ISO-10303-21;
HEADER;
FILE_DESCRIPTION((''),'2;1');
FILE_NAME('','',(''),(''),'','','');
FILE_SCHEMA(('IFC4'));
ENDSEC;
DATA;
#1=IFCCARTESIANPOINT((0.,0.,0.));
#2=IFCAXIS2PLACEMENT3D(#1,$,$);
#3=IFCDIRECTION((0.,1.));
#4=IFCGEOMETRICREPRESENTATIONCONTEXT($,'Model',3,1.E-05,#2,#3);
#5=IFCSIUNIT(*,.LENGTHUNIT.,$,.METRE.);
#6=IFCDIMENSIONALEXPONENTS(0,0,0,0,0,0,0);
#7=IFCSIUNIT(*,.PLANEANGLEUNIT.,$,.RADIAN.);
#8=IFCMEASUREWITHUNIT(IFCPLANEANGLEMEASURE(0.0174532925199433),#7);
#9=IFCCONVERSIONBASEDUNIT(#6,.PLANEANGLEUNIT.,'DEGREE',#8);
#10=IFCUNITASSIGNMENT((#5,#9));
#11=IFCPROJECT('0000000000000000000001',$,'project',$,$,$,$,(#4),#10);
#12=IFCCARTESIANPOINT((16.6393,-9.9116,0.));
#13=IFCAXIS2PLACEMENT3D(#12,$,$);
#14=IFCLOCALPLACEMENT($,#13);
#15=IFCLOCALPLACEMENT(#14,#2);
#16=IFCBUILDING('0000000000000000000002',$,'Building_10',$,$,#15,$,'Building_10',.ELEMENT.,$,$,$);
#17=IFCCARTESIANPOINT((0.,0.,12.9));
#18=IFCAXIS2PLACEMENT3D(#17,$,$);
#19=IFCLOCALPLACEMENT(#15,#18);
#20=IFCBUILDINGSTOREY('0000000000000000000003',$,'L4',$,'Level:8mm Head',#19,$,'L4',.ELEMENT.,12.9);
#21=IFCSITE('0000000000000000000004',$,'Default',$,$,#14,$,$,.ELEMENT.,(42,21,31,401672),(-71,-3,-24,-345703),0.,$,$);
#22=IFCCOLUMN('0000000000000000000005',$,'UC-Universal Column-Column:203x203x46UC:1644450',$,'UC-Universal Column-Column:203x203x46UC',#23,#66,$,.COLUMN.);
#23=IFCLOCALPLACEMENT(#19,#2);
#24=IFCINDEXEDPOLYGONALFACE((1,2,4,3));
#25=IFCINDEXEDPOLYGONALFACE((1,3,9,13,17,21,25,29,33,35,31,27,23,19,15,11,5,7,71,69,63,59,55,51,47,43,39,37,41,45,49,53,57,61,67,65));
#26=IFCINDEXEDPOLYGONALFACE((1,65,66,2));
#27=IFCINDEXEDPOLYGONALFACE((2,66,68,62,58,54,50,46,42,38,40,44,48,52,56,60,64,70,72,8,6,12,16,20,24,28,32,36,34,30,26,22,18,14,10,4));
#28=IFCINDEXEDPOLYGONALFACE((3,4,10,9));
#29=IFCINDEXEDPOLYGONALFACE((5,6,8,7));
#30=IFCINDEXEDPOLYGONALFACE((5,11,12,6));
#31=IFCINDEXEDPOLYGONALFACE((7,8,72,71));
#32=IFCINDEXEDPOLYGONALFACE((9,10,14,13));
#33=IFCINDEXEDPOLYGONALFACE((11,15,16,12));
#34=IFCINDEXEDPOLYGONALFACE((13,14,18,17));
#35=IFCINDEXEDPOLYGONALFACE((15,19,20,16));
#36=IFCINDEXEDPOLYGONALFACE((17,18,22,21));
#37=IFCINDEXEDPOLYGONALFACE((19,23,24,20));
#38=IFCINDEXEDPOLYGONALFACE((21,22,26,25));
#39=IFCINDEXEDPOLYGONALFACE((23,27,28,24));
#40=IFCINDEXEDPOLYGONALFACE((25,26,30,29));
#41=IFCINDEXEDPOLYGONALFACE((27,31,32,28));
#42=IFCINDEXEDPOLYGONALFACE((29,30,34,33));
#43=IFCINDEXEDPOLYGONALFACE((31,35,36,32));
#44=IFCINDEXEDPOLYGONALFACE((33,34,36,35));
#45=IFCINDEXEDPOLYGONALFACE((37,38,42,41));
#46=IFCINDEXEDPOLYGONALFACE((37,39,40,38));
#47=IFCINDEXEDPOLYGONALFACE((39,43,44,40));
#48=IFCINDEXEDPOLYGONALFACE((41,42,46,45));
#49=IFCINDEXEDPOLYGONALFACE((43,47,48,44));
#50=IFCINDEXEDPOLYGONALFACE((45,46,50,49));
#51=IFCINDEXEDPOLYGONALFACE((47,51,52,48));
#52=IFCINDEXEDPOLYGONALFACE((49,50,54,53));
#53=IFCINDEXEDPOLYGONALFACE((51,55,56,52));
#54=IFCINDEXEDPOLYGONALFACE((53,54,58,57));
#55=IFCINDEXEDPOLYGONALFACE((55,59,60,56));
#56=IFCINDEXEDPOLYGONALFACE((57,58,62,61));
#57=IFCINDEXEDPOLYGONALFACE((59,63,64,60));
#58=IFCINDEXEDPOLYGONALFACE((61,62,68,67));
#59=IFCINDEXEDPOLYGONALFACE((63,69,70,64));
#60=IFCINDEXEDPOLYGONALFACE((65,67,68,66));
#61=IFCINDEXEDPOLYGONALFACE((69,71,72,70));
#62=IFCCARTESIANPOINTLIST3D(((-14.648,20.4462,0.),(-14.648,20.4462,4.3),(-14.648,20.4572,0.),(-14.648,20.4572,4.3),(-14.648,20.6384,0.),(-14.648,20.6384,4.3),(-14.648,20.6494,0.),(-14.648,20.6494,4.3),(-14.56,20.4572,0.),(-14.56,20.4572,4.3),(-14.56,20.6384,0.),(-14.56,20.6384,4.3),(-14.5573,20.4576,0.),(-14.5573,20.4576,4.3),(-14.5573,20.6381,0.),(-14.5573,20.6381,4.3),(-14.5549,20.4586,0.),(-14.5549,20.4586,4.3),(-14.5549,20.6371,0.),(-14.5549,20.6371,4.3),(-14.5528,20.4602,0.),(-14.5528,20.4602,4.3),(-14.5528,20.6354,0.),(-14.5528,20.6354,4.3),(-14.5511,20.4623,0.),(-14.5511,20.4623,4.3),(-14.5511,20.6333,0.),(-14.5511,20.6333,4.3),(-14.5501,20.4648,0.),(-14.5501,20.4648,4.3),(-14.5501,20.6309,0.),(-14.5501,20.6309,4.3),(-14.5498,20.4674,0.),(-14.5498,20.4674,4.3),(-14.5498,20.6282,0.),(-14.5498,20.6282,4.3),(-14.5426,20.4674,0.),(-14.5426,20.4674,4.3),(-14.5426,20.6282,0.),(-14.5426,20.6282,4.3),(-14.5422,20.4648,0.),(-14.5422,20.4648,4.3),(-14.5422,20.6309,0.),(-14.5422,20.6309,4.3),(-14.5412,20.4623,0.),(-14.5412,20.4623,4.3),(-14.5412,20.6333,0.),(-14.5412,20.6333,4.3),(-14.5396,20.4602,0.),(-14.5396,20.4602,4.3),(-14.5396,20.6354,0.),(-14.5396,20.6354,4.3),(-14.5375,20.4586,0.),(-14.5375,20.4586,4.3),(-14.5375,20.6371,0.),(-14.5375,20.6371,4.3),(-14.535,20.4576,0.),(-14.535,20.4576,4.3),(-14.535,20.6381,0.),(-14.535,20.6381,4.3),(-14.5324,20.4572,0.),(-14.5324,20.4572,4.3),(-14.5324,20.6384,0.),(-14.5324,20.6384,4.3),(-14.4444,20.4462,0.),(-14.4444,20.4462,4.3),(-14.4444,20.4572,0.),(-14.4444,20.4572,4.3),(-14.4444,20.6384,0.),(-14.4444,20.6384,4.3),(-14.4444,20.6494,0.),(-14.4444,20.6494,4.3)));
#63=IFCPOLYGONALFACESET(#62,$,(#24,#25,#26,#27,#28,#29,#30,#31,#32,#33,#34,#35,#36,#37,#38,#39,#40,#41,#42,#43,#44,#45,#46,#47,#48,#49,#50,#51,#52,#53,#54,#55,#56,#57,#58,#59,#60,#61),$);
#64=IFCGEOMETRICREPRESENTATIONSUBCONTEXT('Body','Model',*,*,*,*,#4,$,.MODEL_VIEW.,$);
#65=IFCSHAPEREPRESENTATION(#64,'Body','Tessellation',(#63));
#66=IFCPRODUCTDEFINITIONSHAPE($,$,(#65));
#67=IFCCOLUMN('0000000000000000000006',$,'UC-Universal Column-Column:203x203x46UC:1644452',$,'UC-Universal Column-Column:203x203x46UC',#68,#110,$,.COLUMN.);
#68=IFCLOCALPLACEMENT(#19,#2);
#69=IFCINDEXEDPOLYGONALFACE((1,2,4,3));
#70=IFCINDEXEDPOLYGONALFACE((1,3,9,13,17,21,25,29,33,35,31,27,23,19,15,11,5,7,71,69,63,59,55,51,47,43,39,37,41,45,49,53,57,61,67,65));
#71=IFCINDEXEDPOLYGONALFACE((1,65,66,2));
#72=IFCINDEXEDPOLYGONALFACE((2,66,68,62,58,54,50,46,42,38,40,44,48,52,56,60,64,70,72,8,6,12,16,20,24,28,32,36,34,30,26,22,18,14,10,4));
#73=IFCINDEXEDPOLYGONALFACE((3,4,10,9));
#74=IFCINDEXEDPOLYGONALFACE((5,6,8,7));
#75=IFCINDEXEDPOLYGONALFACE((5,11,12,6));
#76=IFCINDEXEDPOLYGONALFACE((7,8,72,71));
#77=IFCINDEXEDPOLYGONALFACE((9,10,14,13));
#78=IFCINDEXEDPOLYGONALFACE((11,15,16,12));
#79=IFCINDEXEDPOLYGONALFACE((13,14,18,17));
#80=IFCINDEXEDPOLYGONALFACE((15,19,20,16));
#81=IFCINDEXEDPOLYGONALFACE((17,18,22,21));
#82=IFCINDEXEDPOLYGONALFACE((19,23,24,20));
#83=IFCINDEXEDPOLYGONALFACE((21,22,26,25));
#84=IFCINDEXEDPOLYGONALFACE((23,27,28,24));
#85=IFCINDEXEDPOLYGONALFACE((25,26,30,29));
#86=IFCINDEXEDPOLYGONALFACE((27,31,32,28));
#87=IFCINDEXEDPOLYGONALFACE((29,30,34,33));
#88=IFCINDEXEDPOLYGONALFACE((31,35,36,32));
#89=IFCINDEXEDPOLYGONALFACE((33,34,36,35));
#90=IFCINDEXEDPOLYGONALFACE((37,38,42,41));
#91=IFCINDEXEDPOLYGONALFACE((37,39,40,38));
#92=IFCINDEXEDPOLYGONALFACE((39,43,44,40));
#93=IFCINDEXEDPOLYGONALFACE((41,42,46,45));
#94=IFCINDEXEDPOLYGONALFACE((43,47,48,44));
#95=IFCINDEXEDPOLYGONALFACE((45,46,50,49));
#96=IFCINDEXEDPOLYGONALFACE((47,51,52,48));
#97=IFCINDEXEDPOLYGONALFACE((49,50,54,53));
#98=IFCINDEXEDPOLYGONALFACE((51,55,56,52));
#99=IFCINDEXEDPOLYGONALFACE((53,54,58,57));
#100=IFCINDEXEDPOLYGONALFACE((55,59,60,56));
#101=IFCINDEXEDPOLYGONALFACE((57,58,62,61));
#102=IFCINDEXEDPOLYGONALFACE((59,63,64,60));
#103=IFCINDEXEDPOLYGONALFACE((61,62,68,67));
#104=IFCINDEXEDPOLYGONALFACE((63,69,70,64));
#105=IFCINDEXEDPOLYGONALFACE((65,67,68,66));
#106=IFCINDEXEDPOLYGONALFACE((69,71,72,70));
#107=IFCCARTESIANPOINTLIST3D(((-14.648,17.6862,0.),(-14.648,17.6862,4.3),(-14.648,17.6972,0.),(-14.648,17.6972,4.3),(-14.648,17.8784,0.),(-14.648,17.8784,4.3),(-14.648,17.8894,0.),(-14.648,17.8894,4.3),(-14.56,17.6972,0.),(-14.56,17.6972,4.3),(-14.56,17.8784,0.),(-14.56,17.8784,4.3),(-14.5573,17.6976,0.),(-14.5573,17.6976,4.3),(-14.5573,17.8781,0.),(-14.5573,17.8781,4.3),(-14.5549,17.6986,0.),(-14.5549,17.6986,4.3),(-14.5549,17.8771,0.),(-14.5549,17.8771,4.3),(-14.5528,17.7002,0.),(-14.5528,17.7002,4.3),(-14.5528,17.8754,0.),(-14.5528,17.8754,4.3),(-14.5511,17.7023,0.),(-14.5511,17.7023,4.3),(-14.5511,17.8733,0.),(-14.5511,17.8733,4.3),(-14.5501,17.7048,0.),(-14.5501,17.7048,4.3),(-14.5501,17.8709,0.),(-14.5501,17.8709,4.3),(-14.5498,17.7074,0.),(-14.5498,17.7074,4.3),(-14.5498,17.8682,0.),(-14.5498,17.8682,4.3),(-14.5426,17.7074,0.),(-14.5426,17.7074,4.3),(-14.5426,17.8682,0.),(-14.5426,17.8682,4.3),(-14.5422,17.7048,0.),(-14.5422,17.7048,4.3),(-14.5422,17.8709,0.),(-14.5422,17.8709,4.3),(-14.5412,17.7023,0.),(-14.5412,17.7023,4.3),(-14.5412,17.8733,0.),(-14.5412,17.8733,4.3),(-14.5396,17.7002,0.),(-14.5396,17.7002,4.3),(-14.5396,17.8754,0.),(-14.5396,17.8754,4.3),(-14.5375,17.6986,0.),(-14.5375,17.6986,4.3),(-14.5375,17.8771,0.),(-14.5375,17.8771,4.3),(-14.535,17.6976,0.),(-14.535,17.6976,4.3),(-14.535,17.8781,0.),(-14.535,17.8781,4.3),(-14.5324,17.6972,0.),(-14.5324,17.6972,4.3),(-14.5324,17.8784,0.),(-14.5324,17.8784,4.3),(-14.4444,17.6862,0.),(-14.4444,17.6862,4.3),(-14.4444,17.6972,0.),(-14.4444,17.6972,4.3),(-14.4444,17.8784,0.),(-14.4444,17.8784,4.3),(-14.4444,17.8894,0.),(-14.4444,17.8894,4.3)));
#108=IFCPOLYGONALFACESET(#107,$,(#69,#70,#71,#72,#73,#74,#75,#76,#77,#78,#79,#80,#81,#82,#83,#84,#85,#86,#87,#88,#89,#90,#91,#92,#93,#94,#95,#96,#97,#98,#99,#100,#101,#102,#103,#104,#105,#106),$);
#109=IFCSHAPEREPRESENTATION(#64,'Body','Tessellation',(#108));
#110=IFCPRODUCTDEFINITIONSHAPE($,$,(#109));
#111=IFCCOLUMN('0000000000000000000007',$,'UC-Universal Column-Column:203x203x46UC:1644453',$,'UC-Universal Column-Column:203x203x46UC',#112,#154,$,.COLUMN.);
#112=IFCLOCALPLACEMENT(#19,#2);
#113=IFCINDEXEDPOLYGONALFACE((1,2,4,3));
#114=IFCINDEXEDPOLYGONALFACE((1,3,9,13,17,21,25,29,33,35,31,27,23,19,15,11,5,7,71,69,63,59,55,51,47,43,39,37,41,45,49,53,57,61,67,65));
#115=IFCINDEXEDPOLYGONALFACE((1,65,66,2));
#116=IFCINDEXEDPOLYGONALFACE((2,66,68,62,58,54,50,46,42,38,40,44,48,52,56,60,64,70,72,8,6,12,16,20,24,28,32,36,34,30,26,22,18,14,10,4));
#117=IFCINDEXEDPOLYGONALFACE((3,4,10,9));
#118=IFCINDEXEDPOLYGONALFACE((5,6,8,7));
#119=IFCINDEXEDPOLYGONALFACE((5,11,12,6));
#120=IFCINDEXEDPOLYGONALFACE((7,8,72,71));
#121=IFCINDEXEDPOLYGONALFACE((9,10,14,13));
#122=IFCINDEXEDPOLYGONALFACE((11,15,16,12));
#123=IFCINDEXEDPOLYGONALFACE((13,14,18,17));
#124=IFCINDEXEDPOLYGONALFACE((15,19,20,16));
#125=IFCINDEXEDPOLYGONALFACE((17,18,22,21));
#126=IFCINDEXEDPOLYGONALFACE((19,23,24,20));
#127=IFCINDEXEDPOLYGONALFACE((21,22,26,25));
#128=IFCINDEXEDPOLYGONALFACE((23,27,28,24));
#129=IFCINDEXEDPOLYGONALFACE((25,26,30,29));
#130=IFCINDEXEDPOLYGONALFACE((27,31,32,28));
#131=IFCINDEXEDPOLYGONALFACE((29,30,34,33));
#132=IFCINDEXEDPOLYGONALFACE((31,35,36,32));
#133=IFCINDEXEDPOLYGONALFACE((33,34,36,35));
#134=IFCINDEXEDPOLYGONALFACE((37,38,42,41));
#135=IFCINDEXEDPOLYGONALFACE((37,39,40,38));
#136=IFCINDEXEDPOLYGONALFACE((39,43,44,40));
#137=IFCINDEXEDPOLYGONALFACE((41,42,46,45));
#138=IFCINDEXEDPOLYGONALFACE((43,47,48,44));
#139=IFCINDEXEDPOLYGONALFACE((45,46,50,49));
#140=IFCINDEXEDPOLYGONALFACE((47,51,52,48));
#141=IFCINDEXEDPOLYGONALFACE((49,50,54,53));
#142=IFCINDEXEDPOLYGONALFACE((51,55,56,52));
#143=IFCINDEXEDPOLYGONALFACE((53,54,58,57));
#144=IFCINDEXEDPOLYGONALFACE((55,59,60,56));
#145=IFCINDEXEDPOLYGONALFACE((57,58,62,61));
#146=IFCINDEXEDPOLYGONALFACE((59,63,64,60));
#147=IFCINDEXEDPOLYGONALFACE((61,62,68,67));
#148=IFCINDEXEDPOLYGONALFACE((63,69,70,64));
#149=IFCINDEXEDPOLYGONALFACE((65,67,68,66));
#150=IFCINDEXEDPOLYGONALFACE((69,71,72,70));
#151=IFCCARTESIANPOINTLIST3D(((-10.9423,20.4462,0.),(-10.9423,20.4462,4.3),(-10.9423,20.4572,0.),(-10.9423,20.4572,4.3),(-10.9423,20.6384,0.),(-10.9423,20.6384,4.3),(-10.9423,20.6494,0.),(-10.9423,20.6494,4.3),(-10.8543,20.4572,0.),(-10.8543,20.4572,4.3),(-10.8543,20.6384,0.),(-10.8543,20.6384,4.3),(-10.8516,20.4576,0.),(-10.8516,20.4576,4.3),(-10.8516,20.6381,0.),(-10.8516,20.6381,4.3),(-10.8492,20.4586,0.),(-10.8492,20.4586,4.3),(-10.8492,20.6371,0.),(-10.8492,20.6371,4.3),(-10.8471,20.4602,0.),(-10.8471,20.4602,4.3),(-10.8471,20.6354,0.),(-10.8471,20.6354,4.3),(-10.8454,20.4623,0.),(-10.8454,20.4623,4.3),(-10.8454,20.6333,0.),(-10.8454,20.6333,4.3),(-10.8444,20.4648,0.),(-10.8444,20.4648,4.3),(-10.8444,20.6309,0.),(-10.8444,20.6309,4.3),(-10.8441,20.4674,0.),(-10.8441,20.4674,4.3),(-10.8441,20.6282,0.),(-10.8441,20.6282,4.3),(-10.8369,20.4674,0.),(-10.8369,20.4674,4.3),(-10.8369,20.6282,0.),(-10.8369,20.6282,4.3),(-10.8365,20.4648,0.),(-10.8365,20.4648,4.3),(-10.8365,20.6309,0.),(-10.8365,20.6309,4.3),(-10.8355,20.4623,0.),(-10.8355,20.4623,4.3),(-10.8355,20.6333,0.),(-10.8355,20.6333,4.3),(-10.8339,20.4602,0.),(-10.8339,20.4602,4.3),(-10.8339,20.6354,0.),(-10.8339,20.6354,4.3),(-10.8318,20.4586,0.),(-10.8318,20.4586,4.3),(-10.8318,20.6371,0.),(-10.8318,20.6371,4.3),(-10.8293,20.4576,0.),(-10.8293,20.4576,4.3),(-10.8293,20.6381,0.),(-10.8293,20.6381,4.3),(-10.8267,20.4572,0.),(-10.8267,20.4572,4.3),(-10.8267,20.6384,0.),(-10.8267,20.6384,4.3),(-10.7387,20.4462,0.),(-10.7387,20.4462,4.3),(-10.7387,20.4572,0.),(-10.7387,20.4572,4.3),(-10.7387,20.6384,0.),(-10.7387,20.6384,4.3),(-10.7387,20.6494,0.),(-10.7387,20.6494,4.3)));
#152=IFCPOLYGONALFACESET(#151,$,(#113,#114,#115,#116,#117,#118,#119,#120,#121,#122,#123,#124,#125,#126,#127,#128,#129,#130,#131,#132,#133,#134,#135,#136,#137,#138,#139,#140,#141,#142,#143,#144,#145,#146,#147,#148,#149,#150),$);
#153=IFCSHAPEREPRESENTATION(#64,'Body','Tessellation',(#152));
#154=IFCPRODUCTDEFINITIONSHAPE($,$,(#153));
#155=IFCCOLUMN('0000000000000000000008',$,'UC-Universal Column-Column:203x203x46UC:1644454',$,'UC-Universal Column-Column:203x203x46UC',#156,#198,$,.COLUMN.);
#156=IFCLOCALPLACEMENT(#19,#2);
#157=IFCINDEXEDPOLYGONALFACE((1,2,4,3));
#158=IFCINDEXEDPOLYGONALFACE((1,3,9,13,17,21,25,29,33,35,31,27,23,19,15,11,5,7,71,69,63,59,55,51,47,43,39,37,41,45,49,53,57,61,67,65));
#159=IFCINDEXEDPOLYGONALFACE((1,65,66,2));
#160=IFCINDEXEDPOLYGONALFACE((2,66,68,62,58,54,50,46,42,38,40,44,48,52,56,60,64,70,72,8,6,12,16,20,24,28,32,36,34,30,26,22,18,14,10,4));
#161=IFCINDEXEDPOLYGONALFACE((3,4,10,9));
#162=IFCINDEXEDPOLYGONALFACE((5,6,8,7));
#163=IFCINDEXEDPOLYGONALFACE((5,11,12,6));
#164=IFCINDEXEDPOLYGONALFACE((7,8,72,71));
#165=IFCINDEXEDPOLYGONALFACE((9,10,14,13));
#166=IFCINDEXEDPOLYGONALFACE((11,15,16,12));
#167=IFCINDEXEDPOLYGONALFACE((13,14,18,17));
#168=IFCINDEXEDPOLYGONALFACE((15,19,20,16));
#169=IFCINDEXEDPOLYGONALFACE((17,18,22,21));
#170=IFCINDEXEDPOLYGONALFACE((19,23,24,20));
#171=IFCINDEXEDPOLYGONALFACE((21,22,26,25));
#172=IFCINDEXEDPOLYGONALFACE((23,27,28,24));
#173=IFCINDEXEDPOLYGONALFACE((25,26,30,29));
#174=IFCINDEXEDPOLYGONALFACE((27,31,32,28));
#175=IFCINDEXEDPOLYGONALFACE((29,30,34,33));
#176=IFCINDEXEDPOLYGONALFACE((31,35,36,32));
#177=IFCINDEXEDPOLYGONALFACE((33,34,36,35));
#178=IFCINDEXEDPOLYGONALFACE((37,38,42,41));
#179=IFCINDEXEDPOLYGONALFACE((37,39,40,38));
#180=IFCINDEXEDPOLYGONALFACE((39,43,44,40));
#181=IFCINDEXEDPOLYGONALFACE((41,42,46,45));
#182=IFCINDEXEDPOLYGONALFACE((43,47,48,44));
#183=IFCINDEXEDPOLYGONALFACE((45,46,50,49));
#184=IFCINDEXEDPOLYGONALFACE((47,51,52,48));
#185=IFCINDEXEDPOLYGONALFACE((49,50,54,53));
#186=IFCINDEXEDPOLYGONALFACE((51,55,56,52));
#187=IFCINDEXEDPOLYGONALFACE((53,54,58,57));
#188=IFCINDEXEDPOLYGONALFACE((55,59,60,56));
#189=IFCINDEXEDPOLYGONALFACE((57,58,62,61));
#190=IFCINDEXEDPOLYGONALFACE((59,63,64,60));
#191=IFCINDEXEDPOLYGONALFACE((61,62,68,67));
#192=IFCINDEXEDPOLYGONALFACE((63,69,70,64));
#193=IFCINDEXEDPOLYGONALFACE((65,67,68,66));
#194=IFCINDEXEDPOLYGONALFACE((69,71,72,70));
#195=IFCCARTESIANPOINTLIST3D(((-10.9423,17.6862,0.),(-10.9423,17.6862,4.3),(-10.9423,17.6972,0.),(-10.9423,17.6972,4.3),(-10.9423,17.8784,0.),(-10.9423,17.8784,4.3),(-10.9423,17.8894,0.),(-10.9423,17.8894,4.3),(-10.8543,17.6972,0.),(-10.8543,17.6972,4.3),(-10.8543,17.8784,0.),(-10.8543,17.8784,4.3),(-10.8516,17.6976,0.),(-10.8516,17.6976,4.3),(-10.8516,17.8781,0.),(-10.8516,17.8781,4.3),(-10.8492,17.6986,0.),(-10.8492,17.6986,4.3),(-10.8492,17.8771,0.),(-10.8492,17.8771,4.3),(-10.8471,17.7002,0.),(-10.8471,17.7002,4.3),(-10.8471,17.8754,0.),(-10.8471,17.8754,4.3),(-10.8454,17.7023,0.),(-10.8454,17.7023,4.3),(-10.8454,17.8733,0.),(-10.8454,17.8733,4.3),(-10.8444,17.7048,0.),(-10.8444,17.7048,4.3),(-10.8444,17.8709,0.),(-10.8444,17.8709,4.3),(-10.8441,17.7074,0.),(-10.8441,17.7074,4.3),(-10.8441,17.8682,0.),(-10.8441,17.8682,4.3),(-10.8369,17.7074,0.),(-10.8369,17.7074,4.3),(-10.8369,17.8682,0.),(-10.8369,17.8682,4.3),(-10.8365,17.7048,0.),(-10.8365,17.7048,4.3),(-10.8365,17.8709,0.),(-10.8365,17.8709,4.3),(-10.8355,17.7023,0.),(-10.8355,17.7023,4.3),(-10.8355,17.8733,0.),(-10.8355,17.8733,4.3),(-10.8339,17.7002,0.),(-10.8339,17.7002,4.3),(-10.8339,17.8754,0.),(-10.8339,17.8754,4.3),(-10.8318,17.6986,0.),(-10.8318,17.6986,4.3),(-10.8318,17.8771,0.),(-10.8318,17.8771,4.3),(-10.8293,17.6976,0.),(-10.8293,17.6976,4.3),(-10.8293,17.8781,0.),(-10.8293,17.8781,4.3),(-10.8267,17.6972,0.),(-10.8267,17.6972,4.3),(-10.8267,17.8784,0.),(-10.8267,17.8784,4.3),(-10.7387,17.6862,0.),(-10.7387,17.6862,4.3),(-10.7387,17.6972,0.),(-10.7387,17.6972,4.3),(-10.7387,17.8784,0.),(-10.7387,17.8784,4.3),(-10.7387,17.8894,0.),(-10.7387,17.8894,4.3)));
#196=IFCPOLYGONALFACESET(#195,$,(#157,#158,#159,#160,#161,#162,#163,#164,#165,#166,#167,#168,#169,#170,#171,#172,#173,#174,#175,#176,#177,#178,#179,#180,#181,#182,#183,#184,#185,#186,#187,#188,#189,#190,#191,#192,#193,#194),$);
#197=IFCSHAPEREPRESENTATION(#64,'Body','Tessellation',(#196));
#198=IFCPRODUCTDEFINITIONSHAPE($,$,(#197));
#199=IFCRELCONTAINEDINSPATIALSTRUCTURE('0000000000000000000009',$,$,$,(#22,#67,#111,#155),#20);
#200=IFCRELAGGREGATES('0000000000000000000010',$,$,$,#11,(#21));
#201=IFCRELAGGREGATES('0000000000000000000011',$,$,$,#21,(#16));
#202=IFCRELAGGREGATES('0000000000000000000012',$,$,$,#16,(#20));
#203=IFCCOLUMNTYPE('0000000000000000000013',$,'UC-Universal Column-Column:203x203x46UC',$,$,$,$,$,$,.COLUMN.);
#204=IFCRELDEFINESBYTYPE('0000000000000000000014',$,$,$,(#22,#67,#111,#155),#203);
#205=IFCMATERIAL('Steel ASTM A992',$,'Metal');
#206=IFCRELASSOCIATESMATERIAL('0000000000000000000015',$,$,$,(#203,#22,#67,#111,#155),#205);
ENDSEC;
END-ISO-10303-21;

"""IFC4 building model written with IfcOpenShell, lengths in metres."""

from ifc_helpers import new_model, entity, si_unit, converted_unit, direction, frame, origin, place, context, subcontext, project, spatial, line, arc, indexed_curve, outline, extrude, source, transform, mapped, material, type_object, type_shapes, element, save


model = new_model("IFC4")

# Units and contexts
model_context = context("Model", 3, precision=1e-05, world=origin(), true_north=direction((0.0, 1.0)))
body_context = subcontext(model_context, "Body", "Model", "MODEL_VIEW")
ifc_project = project(units=[si_unit("LENGTHUNIT", "METRE"), converted_unit("PLANEANGLEUNIT", "DEGREE", entity("IfcPlaneAngleMeasure", 0.0174532925199433), si_unit("PLANEANGLEUNIT", "RADIAN"), dimensions=[0, 0, 0, 0, 0, 0, 0])], contexts=[model_context])

# Site, building, storey
site_placement = place(None, frame((16.6393, -9.9116, 0.0)))
site = spatial("IfcSite", under=ifc_project, at=site_placement, Name="Default", CompositionType="ELEMENT", RefLatitude=(42, 21, 31, 401672), RefLongitude=(-71, -3, -24, -345703), RefElevation=0.0)
building_placement = place(site_placement, origin())
building = spatial("IfcBuilding", under=site, at=building_placement, Name="Building_10", LongName="Building_10", CompositionType="ELEMENT")
storey_placement = place(building_placement, frame((0.0, 0.0, 12.9)))
storey = spatial("IfcBuildingStorey", under=building, at=storey_placement, Name="L4", ObjectType="Level:8mm Head", LongName="L4", CompositionType="ELEMENT", Elevation=12.9)

# Columns
ifc_material_1 = material(Name="Steel ASTM A992", Category="Metal")
column_type = type_object("IfcColumnType", Name="UC-Universal Column-Column:203x203x46UC", PredefinedType="COLUMN", material=ifc_material_1)
shared_shape_1 = source(origin(), body_context, "Body", "SweptSolid", [
    extrude(outline(indexed_curve([(-0.1018, -0.1016), (0.1018, -0.1016), (0.1018, -0.0906), (0.0138, -0.0906), (0.0066, -0.0876), (0.0036, -0.0804), (0.0036, 0.0804), (0.0066, 0.0876), (0.0138, 0.0906), (0.1018, 0.0906), (0.1018, 0.1016), (-0.1018, 0.1016), (-0.1018, 0.0906), (-0.0138, 0.0906), (-0.0066, 0.0876), (-0.0036, 0.0804), (-0.0036, -0.0804), (-0.0066, -0.0876), (-0.0138, -0.0906), (-0.1018, -0.0906)], segments=[line(1, 2, 3, 4), arc(4, 5, 6), line(6, 7), arc(7, 8, 9), line(9, 10, 11, 12, 13, 14), arc(14, 15, 16), line(16, 17), arc(17, 18, 19), line(19, 20, 1)], self_intersect=False)), frame((0.0, 0.0, 12.9), z_axis=(0.0, 0.0, 1.0), x_axis=(-1.0, 0.0, 0.0)), (0.0, 0.0, 1.0), 4.3),
])
type_shapes(column_type, [shared_shape_1])
for number, where, name in (
    (1, (-14.5462, 20.5478, -12.9), "UC-Universal Column-Column:203x203x46UC:1644450"),
    (2, (-14.5462, 17.7878, -12.9), "UC-Universal Column-Column:203x203x46UC:1644452"),
    (3, (-10.8405, 20.5478, -12.9), "UC-Universal Column-Column:203x203x46UC:1644453"),
    (4, (-10.8405, 17.7878, -12.9), "UC-Universal Column-Column:203x203x46UC:1644454"),
):
    element("IfcColumn", number, at=place(storey_placement, frame(where)), inside=storey, type_object=column_type, material=ifc_material_1, Name=name, ObjectType="UC-Universal Column-Column:203x203x46UC", PredefinedType="COLUMN", context=body_context, shape_type="MappedRepresentation", body=[
        mapped(shared_shape_1, transform((0.0, 0.0, 0.0), scale=1.0)),
    ])

save(model, "model.ifc")
